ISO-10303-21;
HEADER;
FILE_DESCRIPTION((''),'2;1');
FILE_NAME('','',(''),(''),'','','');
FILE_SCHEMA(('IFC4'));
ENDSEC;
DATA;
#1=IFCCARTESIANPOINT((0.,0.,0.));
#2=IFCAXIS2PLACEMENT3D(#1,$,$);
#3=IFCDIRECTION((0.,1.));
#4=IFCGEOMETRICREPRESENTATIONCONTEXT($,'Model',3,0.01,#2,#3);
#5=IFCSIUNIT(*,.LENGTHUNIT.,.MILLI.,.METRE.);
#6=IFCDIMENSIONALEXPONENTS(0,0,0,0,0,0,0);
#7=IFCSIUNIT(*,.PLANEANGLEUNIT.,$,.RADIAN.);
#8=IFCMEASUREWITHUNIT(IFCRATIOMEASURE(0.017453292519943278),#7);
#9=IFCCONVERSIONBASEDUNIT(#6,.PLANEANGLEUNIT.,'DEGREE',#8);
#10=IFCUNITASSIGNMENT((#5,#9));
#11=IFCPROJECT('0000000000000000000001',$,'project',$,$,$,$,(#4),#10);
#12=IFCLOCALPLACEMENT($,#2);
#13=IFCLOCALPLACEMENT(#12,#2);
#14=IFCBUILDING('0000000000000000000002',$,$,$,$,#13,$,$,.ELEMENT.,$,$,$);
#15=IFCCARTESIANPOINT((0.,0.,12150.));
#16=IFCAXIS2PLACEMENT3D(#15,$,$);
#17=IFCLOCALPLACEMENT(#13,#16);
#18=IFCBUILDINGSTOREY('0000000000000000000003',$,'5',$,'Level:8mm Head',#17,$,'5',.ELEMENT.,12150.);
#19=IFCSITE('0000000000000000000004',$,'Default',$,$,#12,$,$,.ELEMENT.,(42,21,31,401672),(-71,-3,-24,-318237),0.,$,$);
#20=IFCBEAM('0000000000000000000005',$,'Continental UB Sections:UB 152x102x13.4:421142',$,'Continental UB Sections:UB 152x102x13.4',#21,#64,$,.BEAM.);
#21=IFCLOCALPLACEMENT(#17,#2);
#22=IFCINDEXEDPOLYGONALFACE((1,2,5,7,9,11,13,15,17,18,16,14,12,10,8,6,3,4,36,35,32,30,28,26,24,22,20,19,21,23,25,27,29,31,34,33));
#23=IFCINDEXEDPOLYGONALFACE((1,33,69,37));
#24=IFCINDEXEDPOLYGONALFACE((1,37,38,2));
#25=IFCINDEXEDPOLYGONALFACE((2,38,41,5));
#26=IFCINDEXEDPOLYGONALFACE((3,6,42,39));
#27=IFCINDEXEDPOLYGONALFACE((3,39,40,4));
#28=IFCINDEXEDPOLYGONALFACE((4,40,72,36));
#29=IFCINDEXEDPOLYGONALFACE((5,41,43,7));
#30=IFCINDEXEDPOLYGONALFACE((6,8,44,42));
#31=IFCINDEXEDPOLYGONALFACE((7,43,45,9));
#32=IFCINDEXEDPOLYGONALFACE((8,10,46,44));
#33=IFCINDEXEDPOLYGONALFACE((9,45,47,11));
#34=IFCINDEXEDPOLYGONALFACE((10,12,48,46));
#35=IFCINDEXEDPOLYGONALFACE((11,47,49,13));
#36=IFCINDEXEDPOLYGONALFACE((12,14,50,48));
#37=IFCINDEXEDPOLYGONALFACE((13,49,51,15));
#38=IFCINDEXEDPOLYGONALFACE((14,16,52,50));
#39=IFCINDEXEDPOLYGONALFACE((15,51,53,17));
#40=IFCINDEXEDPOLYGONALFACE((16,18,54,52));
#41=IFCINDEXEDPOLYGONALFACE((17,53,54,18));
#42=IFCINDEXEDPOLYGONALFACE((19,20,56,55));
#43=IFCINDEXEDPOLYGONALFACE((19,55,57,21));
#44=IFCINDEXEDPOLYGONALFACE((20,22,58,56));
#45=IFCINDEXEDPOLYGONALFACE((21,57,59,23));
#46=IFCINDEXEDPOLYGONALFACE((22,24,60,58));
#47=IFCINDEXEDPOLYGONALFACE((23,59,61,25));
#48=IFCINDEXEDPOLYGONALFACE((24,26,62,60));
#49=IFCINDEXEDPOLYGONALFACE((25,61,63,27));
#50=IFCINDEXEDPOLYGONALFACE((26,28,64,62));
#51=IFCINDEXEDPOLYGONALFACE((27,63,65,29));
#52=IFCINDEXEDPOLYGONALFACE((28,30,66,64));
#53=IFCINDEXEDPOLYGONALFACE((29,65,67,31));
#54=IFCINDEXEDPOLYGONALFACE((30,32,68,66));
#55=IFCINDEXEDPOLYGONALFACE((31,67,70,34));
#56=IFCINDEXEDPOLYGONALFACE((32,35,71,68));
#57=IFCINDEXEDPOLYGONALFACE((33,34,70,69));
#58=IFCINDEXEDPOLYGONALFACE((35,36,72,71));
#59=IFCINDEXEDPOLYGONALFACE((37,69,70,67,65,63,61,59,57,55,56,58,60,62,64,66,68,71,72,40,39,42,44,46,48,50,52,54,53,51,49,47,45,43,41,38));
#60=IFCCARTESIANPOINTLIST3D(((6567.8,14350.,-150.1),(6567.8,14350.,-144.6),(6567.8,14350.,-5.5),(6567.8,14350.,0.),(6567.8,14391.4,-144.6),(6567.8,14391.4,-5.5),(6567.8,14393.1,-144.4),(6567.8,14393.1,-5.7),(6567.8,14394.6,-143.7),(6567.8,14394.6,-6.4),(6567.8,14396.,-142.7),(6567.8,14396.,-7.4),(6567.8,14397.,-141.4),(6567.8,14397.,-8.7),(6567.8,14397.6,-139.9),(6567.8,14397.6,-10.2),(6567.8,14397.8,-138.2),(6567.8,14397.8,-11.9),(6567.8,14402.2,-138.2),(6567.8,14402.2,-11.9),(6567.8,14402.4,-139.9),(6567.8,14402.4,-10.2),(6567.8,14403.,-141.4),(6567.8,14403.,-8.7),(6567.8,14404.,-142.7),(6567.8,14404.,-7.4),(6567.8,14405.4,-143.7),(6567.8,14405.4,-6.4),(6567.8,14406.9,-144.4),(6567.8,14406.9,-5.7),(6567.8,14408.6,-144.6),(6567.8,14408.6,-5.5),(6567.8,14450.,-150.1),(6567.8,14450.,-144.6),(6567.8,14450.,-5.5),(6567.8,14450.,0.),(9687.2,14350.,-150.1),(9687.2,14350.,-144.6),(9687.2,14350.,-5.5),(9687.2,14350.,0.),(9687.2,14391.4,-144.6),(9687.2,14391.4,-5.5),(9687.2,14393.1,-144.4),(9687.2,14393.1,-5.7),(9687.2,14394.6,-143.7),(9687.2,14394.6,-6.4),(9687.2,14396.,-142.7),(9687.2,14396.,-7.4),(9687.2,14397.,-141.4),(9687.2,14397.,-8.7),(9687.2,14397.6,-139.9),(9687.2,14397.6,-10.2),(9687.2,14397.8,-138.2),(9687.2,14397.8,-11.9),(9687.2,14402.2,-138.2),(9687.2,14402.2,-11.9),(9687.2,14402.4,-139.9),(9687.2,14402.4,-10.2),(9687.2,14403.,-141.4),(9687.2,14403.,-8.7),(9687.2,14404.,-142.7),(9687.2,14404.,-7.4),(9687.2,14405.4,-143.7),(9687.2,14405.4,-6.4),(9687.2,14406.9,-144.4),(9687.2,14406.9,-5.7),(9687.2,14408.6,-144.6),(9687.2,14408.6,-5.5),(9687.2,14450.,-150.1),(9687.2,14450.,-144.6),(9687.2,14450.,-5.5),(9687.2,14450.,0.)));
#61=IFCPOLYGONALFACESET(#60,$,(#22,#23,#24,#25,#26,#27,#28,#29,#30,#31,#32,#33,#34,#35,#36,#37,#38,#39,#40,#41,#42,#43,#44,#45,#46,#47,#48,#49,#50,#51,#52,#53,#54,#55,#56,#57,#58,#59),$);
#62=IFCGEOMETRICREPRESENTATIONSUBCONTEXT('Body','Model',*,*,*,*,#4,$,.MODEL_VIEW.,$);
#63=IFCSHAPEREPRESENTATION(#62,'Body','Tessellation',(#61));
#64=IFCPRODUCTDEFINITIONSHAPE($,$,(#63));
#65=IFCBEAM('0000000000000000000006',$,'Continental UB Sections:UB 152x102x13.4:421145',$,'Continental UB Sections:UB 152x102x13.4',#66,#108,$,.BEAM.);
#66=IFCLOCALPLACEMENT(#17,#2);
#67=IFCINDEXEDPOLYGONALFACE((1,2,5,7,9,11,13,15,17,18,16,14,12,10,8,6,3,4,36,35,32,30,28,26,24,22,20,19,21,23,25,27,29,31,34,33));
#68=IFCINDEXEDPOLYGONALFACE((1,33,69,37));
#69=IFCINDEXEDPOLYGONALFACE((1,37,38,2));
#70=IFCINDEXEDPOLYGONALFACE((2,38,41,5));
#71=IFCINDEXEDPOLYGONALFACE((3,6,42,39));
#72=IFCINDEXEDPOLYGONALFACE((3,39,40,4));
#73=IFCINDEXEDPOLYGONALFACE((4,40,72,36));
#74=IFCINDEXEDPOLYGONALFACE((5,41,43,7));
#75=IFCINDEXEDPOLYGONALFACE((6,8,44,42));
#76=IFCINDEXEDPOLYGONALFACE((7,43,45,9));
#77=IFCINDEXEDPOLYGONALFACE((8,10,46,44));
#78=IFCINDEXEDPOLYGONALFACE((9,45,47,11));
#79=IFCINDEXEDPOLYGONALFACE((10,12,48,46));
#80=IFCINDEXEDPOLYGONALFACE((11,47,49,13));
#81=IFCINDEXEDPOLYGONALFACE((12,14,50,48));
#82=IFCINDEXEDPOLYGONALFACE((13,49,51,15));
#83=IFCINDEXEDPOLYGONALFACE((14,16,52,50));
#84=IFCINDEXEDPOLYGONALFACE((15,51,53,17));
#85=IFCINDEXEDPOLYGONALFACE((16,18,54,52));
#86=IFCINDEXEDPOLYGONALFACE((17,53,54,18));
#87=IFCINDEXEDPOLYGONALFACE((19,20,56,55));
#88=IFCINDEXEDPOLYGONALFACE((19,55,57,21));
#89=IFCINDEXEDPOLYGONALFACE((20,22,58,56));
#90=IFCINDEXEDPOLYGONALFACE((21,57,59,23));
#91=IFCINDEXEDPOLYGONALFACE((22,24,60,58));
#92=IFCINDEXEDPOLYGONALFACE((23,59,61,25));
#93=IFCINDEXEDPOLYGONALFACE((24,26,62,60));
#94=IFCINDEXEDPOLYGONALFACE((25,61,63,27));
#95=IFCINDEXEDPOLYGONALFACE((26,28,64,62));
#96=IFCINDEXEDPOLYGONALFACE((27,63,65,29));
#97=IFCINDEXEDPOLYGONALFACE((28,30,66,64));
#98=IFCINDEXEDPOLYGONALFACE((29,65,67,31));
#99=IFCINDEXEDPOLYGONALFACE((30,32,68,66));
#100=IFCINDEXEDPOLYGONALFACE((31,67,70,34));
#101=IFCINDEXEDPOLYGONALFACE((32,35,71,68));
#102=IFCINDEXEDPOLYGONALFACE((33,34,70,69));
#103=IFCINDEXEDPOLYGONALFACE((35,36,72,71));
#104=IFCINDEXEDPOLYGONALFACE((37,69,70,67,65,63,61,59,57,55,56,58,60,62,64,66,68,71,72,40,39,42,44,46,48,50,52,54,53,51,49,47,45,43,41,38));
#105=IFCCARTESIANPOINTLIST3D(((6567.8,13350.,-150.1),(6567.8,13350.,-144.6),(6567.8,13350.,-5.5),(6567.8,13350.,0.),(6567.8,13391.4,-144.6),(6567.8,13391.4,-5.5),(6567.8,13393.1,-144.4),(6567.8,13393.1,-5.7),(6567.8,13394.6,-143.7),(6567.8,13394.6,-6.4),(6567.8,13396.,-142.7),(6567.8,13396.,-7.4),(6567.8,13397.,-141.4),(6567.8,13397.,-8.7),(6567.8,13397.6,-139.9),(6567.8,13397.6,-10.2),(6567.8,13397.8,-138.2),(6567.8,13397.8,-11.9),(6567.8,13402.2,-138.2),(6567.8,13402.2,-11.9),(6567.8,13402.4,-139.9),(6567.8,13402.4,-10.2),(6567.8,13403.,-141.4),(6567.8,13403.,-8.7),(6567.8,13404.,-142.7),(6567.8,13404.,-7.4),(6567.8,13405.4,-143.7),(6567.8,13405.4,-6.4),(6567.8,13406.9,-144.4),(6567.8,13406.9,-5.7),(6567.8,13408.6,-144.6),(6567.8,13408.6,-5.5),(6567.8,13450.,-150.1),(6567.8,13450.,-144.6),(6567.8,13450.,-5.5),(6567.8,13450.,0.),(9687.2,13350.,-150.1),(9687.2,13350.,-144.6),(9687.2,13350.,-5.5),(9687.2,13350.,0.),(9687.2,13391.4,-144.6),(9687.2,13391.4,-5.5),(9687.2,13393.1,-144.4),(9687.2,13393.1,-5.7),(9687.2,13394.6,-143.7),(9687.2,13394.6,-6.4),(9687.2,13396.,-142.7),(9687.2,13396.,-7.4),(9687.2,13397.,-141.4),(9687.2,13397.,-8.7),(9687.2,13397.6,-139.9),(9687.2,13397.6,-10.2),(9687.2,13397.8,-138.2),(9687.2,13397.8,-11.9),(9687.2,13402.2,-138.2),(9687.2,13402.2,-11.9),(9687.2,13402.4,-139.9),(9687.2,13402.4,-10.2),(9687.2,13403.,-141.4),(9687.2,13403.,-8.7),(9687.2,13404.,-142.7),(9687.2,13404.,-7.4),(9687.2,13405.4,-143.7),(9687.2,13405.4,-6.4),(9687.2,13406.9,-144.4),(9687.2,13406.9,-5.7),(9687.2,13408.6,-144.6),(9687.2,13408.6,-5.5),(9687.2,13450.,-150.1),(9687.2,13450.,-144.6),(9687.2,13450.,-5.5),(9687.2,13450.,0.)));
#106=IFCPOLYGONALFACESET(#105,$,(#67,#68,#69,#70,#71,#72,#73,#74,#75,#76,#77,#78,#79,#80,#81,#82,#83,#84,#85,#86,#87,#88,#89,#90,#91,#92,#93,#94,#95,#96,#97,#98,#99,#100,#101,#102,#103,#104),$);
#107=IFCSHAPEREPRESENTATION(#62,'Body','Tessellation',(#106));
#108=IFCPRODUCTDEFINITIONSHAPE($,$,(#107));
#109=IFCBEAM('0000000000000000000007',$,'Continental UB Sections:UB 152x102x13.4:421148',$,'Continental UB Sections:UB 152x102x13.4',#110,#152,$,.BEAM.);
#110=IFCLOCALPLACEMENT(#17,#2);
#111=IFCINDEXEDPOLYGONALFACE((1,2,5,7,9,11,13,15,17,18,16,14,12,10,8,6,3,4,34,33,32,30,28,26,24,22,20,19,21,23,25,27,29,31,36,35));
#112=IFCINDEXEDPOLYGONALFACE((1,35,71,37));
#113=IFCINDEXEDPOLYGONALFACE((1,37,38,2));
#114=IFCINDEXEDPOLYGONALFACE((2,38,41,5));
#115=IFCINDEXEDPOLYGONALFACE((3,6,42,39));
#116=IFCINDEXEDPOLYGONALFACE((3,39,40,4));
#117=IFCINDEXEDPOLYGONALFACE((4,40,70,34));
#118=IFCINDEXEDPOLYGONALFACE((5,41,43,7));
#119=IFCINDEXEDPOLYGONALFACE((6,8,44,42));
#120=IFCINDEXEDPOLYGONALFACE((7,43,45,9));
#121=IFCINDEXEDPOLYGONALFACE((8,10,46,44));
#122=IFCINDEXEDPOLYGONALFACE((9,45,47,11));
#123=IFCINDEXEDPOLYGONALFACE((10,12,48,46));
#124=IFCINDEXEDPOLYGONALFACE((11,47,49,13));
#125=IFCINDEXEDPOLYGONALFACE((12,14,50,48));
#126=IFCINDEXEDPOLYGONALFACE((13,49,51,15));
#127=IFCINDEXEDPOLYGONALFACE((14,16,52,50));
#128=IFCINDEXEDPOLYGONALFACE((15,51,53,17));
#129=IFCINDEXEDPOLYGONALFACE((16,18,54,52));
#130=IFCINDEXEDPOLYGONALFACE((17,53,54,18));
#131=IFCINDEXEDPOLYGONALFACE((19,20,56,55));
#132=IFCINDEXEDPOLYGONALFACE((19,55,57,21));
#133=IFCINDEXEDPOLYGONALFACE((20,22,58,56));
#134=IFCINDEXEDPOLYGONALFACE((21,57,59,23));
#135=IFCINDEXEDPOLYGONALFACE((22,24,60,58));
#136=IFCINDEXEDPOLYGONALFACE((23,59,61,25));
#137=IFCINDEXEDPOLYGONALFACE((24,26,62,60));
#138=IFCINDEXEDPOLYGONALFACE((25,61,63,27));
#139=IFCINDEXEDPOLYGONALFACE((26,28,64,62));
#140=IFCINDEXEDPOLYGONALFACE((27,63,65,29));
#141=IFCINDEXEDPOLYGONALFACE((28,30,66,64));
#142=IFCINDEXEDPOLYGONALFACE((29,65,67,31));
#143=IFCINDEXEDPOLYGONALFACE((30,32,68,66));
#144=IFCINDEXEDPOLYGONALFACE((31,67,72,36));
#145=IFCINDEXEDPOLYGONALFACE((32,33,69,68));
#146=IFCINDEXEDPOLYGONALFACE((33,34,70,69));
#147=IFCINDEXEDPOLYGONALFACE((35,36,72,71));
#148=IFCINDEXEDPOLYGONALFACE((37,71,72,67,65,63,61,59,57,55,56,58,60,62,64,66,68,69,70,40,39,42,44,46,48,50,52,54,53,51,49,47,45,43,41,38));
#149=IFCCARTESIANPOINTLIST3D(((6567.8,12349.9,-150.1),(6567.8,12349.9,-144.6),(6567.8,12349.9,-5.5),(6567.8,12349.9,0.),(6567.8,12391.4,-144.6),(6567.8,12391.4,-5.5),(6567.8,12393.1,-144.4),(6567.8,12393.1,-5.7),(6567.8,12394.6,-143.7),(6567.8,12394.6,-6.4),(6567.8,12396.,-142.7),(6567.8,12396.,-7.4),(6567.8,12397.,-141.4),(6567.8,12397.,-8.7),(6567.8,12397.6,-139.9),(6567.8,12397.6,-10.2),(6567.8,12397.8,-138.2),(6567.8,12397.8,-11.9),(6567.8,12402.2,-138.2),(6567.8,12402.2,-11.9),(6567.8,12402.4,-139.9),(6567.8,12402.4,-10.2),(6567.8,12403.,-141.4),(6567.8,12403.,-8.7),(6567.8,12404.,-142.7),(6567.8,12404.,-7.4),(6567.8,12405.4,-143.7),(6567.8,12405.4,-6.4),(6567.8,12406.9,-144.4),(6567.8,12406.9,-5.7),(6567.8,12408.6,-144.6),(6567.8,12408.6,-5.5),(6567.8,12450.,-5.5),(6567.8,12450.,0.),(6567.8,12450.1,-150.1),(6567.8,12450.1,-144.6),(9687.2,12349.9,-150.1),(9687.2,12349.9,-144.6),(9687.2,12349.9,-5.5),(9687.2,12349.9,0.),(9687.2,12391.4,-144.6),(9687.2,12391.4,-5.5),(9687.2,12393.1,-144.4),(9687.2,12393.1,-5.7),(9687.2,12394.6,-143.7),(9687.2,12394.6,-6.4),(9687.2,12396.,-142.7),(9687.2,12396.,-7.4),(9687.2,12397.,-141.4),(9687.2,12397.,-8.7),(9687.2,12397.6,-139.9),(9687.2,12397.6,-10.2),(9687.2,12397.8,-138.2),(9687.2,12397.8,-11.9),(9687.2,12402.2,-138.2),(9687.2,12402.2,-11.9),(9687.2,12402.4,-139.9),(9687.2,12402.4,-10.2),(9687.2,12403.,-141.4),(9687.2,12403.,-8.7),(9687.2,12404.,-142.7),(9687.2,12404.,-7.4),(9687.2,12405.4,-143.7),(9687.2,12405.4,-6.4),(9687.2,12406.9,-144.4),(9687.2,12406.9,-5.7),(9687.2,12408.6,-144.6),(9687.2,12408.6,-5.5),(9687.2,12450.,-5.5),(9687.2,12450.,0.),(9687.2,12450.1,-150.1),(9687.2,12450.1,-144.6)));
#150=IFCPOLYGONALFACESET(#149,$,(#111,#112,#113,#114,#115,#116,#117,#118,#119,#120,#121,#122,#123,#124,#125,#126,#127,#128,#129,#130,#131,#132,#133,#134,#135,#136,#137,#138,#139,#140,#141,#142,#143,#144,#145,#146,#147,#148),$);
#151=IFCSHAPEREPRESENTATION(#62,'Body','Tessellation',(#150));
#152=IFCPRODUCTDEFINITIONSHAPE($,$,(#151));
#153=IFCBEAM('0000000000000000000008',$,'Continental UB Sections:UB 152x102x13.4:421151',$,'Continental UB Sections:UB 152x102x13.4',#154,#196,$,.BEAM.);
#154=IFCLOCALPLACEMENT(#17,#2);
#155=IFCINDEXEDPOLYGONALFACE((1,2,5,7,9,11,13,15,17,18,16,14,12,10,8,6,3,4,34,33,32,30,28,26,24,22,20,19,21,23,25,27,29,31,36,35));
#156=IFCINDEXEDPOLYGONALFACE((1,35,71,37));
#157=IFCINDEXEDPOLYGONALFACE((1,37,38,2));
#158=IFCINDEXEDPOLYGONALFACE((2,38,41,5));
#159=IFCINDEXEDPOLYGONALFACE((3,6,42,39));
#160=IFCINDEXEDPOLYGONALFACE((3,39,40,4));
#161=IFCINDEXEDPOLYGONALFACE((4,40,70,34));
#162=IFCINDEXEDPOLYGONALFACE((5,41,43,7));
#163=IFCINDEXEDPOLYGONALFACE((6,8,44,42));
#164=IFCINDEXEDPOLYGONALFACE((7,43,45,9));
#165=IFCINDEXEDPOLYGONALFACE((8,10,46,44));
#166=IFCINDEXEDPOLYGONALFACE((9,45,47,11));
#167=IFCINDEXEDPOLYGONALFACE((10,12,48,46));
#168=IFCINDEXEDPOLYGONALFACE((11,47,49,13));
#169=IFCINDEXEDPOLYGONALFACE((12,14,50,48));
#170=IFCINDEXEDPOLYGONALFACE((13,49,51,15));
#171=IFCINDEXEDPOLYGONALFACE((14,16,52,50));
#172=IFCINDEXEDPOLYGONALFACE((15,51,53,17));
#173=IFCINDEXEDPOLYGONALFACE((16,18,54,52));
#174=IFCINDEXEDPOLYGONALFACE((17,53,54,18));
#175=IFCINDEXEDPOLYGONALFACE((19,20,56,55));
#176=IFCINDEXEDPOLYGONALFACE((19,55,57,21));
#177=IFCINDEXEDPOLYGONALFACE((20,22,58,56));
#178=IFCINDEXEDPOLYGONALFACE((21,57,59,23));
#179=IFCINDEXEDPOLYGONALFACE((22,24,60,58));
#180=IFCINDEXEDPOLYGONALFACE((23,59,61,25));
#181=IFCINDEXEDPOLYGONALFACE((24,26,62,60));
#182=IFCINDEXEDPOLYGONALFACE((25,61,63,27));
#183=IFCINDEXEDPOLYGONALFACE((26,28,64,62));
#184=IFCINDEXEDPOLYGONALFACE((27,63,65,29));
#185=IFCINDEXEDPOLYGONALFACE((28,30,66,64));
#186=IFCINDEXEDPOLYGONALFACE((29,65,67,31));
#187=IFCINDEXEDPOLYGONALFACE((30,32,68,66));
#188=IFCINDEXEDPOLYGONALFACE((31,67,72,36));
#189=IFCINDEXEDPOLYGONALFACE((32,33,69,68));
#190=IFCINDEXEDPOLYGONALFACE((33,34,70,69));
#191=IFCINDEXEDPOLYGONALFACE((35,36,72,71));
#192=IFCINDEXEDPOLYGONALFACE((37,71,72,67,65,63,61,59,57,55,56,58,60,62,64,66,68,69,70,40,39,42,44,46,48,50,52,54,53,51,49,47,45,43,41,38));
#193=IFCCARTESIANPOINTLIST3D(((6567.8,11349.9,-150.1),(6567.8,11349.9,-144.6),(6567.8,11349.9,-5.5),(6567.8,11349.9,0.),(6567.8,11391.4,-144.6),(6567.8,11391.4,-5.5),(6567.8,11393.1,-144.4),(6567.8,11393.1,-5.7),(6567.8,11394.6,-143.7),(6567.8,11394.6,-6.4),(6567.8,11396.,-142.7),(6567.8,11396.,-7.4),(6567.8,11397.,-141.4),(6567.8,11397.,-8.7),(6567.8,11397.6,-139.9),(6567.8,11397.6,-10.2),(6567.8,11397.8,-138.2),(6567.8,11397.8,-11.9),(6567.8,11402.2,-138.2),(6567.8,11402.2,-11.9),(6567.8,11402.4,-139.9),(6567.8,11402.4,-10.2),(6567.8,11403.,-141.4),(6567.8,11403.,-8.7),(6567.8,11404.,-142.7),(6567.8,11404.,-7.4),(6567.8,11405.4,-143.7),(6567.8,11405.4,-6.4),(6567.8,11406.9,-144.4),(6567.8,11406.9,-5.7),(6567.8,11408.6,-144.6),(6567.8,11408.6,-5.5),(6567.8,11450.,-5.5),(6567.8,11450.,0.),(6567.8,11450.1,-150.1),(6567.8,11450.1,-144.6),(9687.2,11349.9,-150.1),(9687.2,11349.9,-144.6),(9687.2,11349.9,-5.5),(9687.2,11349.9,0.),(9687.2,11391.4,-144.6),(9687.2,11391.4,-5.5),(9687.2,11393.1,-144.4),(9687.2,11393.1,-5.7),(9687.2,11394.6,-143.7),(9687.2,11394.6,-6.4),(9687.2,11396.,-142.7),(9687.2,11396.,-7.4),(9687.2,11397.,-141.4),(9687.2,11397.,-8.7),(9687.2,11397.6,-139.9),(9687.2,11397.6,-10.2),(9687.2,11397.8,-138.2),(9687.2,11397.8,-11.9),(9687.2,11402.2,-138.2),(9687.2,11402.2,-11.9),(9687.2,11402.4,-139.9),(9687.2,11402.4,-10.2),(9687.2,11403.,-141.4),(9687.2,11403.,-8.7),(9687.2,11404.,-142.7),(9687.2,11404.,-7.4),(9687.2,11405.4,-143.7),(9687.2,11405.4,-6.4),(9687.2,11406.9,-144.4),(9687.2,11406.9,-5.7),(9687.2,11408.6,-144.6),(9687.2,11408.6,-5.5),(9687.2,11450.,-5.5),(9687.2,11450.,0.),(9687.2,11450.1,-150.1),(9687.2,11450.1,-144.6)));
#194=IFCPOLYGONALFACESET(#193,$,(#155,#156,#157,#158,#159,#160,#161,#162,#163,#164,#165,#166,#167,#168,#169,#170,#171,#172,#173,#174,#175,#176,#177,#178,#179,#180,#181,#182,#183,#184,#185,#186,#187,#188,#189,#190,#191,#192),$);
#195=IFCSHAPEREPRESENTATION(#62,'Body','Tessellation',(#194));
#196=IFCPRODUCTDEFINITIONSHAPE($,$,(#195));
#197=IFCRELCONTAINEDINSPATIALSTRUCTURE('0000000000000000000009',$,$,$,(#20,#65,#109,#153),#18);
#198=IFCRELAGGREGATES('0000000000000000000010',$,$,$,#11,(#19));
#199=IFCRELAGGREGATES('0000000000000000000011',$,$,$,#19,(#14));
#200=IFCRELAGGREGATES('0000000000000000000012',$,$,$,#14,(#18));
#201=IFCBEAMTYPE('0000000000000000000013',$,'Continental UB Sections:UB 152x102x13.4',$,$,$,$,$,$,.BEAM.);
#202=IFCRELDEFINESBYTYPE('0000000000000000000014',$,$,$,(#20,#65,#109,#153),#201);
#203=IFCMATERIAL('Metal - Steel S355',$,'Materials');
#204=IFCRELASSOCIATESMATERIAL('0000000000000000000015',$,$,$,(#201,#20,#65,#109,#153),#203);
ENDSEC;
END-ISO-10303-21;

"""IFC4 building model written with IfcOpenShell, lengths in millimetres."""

from ifc_helpers import new_model, entity, si_unit, converted_unit, direction, frame, origin, place, context, subcontext, project, spatial, line, arc, indexed_curve, outline, extrude, source, transform, mapped, material, type_object, type_shapes, element, save


model = new_model("IFC4")

# Units and contexts
model_context = context("Model", 3, precision=0.01, world=origin(), true_north=direction((0.0, 1.0)))
body_context = subcontext(model_context, "Body", "Model", "MODEL_VIEW")
ifc_project = project(units=[si_unit("LENGTHUNIT", "METRE", prefix="MILLI"), converted_unit("PLANEANGLEUNIT", "DEGREE", entity("IfcRatioMeasure", 0.017453292519943278), si_unit("PLANEANGLEUNIT", "RADIAN"), dimensions=[0, 0, 0, 0, 0, 0, 0])], contexts=[model_context])

# Site, building, storey
site_placement = place(None, origin())
site = spatial("IfcSite", under=ifc_project, at=site_placement, Name="Default", CompositionType="ELEMENT", RefLatitude=(42, 21, 31, 401672), RefLongitude=(-71, -3, -24, -318237), RefElevation=0.0)
building_placement = place(site_placement, origin())
building = spatial("IfcBuilding", under=site, at=building_placement, CompositionType="ELEMENT")
storey_placement = place(building_placement, frame((0.0, 0.0, 12150.0)))
storey = spatial("IfcBuildingStorey", under=building, at=storey_placement, Name="5", ObjectType="Level:8mm Head", LongName="5", CompositionType="ELEMENT", Elevation=12150.0)

# Beams
ifc_material = material(Name="Metal - Steel S355", Category="Materials")
beam_type_1 = type_object("IfcBeamType", Name="Continental UB Sections:UB 152x102x13.4", PredefinedType="BEAM", material=ifc_material)
shared_shape_1 = source(origin(), body_context, "Body", "SweptSolid", [
    extrude(outline(indexed_curve([(-75.0, -50.1), (-69.6, -50.1), (-69.6, -8.5), (-67.7, -4.0), (-63.2, -2.1), (63.1, -2.1), (67.7, -4.0), (69.5, -8.5), (69.5, -50.1), (75.1, -50.1), (75.1, 50.1), (69.5, 50.1), (69.5, 8.6), (67.7, 4.0), (63.1, 2.2), (-63.2, 2.2), (-67.7, 4.0), (-69.6, 8.6), (-69.6, 50.0), (-75.0, 50.0)], segments=[line(1, 2, 3), arc(3, 4, 5), line(5, 6), arc(6, 7, 8), line(8, 9, 10, 11, 12, 13), arc(13, 14, 15), line(15, 16), arc(16, 17, 18), line(18, 19, 20, 1)], self_intersect=False)), frame((-1559.7, 0.0, 0.0), z_axis=(1.0, 0.0, 0.0), x_axis=(0.0, 0.0, -1.0)), (0.0, 0.0, 1.0), 3119.4),
])
type_shapes(beam_type_1, [shared_shape_1])
for number, where, name in (
    (1, (8127.5, 14400.0, -75.1), "Continental UB Sections:UB 152x102x13.4:421142"),
    (2, (8127.5, 13400.0, -75.1), "Continental UB Sections:UB 152x102x13.4:421145"),
    (3, (8127.5, 12400.0, -75.1), "Continental UB Sections:UB 152x102x13.4:421148"),
    (4, (8127.5, 11400.0, -75.1), "Continental UB Sections:UB 152x102x13.4:421151"),
):
    element("IfcBeam", number, at=place(storey_placement, frame(where)), inside=storey, type_object=beam_type_1, material=ifc_material, Name=name, ObjectType="Continental UB Sections:UB 152x102x13.4", PredefinedType="BEAM", context=body_context, shape_type="MappedRepresentation", body=[
        mapped(shared_shape_1, transform((0.0, 0.0, 0.0), scale=1.0)),
    ])

save(model, "model.ifc")
